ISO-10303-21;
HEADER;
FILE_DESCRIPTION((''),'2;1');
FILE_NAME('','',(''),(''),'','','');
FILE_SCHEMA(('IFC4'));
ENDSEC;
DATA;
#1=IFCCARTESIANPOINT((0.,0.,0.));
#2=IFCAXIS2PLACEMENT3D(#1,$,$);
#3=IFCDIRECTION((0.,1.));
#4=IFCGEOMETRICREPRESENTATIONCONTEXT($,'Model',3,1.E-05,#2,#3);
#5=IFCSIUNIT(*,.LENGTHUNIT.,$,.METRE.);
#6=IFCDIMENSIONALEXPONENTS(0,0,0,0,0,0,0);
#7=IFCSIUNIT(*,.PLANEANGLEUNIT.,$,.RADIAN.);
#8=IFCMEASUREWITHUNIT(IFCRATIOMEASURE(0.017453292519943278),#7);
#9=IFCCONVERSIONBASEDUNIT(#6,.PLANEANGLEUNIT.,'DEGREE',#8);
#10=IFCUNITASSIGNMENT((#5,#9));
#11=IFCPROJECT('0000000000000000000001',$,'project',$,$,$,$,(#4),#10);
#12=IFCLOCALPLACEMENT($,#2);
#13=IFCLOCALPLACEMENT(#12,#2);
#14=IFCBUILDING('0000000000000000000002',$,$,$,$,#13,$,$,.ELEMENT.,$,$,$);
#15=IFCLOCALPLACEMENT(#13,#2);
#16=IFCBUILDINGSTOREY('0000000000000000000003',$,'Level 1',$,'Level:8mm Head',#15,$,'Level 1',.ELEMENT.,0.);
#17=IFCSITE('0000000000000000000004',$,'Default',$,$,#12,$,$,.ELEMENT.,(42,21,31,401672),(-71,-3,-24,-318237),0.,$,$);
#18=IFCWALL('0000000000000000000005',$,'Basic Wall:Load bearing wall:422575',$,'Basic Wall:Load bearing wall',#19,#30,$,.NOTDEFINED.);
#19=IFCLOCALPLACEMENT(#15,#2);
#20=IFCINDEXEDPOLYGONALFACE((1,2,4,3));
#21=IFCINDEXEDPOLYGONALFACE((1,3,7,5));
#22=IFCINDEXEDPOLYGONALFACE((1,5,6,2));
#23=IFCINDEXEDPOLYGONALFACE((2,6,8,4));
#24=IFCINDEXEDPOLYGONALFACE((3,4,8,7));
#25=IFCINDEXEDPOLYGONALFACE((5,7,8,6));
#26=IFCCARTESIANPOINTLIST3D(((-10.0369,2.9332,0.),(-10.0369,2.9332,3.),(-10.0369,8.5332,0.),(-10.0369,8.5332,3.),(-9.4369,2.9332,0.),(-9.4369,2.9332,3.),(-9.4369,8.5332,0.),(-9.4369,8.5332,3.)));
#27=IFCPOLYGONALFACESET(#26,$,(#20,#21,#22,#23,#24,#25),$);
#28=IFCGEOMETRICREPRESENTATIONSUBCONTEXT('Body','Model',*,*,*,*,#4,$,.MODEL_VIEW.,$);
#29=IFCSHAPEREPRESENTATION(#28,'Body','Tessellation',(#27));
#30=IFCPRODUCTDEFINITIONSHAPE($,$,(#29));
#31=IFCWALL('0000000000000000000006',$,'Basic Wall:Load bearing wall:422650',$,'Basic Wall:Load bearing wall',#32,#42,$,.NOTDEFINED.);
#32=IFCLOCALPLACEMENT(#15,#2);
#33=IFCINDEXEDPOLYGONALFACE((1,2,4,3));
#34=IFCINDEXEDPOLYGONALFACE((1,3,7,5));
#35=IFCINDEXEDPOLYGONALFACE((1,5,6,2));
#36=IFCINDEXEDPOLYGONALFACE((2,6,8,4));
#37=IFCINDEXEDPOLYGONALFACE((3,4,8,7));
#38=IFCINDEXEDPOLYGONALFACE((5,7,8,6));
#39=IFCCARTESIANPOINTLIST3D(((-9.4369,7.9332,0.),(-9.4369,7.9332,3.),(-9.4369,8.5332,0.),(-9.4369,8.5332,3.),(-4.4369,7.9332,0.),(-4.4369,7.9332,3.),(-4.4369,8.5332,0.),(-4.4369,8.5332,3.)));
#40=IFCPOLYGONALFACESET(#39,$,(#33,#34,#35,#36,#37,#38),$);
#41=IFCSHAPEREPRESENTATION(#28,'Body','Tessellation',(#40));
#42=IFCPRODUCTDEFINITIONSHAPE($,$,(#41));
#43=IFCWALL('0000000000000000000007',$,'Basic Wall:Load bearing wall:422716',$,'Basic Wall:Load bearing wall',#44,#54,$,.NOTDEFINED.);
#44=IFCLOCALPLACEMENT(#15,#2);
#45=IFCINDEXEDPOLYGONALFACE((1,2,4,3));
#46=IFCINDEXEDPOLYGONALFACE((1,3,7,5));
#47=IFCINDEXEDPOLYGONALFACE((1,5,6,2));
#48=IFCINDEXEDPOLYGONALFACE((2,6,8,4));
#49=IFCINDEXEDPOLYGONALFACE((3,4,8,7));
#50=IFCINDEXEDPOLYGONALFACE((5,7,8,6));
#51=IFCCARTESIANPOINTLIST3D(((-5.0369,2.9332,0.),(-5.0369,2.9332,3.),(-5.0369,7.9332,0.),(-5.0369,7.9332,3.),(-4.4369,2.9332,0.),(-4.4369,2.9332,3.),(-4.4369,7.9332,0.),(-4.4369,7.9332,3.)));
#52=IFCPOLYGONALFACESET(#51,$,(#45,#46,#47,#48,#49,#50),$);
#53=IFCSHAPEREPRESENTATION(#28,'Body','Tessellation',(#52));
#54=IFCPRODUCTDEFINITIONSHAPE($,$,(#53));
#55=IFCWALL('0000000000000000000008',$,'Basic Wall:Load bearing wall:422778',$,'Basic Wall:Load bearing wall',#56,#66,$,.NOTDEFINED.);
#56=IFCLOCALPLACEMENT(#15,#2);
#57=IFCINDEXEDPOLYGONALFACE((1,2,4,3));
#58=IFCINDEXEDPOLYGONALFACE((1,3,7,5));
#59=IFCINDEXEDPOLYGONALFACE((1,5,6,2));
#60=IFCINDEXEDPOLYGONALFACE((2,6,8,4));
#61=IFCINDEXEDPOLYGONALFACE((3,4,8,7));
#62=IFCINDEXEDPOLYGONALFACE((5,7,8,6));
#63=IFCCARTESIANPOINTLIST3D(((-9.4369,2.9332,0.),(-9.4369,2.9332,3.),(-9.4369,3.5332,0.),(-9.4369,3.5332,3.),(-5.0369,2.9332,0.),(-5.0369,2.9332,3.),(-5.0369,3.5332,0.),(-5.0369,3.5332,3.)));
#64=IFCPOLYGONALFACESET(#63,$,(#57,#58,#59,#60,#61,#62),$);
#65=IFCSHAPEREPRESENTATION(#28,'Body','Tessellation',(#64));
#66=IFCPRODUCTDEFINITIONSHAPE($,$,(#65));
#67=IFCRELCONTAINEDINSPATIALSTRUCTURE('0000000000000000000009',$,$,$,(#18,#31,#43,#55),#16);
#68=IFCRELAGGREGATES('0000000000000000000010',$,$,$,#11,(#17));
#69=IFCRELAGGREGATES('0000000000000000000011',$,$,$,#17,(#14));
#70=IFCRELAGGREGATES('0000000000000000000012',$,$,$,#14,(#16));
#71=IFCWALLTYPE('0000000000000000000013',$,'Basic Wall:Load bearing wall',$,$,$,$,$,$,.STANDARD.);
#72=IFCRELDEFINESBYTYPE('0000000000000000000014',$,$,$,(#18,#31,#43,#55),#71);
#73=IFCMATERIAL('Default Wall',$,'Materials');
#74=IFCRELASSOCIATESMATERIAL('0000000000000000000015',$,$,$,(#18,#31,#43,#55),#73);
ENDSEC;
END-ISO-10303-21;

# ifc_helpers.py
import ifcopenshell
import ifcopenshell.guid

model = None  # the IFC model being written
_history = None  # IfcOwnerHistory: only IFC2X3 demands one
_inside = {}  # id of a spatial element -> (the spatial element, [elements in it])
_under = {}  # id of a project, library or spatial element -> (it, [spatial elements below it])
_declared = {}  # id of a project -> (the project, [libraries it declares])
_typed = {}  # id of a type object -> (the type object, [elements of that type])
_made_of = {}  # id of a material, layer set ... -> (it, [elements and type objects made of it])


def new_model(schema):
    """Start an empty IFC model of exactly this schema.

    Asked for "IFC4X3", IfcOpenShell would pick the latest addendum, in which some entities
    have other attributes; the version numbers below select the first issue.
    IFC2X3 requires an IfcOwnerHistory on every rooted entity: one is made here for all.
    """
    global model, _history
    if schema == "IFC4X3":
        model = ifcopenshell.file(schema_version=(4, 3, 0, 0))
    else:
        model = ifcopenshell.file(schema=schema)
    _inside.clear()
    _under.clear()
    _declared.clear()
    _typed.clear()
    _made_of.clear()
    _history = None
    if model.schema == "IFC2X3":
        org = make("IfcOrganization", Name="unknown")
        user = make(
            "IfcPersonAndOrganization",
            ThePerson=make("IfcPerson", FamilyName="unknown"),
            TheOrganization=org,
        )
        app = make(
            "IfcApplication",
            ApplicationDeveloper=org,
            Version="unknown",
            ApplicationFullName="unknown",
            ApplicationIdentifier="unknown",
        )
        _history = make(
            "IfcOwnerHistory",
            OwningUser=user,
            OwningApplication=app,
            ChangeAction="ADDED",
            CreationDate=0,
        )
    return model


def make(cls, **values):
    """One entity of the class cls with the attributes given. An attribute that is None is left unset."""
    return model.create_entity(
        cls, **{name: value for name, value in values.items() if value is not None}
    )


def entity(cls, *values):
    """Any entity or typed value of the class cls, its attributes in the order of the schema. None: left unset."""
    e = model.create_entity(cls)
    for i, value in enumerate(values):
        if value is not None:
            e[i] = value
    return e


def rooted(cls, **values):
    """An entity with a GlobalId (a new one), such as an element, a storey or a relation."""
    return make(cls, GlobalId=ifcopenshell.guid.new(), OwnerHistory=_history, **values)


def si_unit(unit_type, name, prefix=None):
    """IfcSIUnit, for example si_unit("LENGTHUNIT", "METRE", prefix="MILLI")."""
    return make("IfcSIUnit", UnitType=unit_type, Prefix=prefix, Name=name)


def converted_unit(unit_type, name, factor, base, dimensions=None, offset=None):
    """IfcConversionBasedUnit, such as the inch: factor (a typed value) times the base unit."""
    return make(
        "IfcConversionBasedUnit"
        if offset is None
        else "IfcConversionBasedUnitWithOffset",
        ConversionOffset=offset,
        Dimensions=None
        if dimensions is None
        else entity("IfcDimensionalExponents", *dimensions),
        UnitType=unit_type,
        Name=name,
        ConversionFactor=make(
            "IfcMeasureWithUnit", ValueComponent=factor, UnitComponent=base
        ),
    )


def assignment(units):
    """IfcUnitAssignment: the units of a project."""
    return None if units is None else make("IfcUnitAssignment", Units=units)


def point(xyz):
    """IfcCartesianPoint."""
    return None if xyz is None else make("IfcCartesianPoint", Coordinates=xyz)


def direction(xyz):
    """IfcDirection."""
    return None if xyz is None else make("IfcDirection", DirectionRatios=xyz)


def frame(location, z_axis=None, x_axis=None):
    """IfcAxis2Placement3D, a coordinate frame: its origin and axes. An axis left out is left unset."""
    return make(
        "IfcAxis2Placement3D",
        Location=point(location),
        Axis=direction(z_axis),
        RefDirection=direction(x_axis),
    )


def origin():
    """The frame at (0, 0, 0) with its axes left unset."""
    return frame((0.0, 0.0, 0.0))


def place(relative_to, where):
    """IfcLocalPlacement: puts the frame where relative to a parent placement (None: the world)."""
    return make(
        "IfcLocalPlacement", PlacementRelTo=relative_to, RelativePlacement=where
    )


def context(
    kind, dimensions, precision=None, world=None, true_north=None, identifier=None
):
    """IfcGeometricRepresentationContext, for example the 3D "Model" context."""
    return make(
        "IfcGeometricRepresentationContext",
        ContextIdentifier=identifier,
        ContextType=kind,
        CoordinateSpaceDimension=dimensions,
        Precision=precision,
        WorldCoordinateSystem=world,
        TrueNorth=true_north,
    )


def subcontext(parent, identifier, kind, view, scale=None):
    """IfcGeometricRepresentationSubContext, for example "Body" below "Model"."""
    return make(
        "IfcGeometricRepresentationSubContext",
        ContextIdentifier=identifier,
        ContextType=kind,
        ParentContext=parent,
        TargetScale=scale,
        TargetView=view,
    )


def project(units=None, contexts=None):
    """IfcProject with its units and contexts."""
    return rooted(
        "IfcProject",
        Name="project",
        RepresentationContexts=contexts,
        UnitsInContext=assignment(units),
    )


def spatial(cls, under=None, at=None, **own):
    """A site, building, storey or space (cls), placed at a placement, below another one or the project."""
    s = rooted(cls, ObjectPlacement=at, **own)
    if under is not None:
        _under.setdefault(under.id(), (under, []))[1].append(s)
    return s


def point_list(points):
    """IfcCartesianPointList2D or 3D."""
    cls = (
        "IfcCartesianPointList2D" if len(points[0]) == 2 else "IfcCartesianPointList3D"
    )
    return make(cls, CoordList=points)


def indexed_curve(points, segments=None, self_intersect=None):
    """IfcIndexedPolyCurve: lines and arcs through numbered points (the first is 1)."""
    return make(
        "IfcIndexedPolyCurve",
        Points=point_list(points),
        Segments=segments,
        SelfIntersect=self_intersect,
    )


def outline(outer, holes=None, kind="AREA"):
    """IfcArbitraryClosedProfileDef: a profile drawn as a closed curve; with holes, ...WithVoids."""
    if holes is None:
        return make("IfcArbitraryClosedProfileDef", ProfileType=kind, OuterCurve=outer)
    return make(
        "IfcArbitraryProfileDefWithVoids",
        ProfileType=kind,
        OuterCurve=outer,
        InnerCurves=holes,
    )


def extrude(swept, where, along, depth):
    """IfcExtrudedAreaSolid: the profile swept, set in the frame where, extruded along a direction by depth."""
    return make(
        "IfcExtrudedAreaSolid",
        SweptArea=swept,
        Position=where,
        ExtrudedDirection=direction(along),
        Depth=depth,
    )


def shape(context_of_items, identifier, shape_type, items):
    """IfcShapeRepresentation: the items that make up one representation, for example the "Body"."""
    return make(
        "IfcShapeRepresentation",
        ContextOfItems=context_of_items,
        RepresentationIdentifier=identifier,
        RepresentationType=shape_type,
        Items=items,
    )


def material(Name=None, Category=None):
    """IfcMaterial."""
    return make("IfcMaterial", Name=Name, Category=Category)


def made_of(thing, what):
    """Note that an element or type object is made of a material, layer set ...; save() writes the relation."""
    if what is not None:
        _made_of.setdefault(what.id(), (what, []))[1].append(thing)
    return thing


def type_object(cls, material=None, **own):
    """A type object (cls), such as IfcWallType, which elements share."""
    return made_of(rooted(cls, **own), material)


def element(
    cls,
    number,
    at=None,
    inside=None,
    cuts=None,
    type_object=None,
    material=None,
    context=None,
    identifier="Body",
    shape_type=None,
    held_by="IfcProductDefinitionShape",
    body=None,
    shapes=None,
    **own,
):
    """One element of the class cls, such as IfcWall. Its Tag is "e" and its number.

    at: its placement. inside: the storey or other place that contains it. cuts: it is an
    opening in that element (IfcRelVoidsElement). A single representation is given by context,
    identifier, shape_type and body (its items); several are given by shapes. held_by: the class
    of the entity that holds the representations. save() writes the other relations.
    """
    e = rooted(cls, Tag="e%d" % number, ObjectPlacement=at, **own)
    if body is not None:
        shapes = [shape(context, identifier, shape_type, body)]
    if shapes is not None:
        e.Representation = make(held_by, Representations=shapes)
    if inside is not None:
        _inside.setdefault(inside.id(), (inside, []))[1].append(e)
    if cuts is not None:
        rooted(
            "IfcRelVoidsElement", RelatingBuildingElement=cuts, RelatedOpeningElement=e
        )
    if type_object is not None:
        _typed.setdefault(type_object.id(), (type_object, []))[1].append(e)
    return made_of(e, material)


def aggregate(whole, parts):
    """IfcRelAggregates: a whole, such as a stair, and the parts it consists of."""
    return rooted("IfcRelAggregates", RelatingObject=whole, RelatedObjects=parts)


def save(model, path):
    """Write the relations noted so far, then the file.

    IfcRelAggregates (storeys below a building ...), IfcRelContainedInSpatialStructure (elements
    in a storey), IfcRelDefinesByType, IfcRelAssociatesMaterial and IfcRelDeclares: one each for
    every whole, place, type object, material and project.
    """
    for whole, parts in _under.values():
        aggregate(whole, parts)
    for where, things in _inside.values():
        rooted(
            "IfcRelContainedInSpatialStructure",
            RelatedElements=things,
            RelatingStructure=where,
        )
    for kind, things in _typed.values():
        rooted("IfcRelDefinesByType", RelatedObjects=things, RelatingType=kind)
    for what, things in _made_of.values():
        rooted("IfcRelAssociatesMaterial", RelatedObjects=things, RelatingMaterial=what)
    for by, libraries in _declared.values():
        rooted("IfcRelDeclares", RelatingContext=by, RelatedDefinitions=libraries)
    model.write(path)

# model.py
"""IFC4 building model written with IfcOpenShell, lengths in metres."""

from ifc_helpers import new_model, entity, si_unit, converted_unit, direction, frame, origin, place, context, subcontext, project, spatial, indexed_curve, outline, extrude, material, type_object, element, save


model = new_model("IFC4")

# Units and contexts
model_context = context("Model", 3, precision=1e-05, world=origin(), true_north=direction((0.0, 1.0)))
body_context = subcontext(model_context, "Body", "Model", "MODEL_VIEW")
ifc_project = project(units=[si_unit("LENGTHUNIT", "METRE"), converted_unit("PLANEANGLEUNIT", "DEGREE", entity("IfcRatioMeasure", 0.017453292519943278), si_unit("PLANEANGLEUNIT", "RADIAN"), dimensions=[0, 0, 0, 0, 0, 0, 0])], contexts=[model_context])

# Site, building, storey
site_placement = place(None, origin())
site = spatial("IfcSite", under=ifc_project, at=site_placement, Name="Default", CompositionType="ELEMENT", RefLatitude=(42, 21, 31, 401672), RefLongitude=(-71, -3, -24, -318237), RefElevation=0.0)
building_placement = place(site_placement, origin())
building = spatial("IfcBuilding", under=site, at=building_placement, CompositionType="ELEMENT")
storey_placement = place(building_placement, origin())
storey = spatial("IfcBuildingStorey", under=building, at=storey_placement, Name="Level 1", ObjectType="Level:8mm Head", LongName="Level 1", CompositionType="ELEMENT", Elevation=0.0)

# Walls
ifc_material = material(Name="Default Wall", Category="Materials")
wall_type = type_object("IfcWallType", Name="Basic Wall:Load bearing wall", PredefinedType="STANDARD")
wall_1_placement = place(storey_placement, frame((-9.7369, 2.9332, 0.0), z_axis=(0.0, 0.0, 1.0), x_axis=(0.0, 1.0, 0.0)))
element("IfcWall", 1, at=wall_1_placement, inside=storey, type_object=wall_type, material=ifc_material, Name="Basic Wall:Load bearing wall:422575", ObjectType="Basic Wall:Load bearing wall", PredefinedType="NOTDEFINED", context=body_context, shape_type="SweptSolid", body=[
    extrude(outline(indexed_curve([(5.6, 0.3), (0.0, 0.3), (0.0, -0.3), (5.6, -0.3), (5.6, 0.3)], self_intersect=False)), origin(), (0.0, 0.0, 1.0), 3.0),
])
wall_2_placement = place(storey_placement, frame((-9.4369, 8.2332, 0.0)))
element("IfcWall", 2, at=wall_2_placement, inside=storey, type_object=wall_type, material=ifc_material, Name="Basic Wall:Load bearing wall:422650", ObjectType="Basic Wall:Load bearing wall", PredefinedType="NOTDEFINED", context=body_context, shape_type="SweptSolid", body=[
    extrude(outline(indexed_curve([(5.0, 0.3), (0.0, 0.3), (0.0, -0.3), (5.0, -0.3), (5.0, 0.3)], self_intersect=False)), origin(), (0.0, 0.0, 1.0), 3.0),
])
wall_3_placement = place(storey_placement, frame((-4.7369, 7.9332, 0.0), z_axis=(0.0, 0.0, 1.0), x_axis=(0.0, -1.0, 0.0)))
element("IfcWall", 3, at=wall_3_placement, inside=storey, type_object=wall_type, material=ifc_material, Name="Basic Wall:Load bearing wall:422716", ObjectType="Basic Wall:Load bearing wall", PredefinedType="NOTDEFINED", context=body_context, shape_type="SweptSolid", body=[
    extrude(outline(indexed_curve([(5.0, 0.3), (0.0, 0.3), (0.0, -0.3), (5.0, -0.3), (5.0, 0.3)], self_intersect=False)), origin(), (0.0, 0.0, 1.0), 3.0),
])
wall_4_placement = place(storey_placement, frame((-5.0369, 3.2332, 0.0), z_axis=(0.0, 0.0, 1.0), x_axis=(-1.0, 0.0, 0.0)))
element("IfcWall", 4, at=wall_4_placement, inside=storey, type_object=wall_type, material=ifc_material, Name="Basic Wall:Load bearing wall:422778", ObjectType="Basic Wall:Load bearing wall", PredefinedType="NOTDEFINED", context=body_context, shape_type="SweptSolid", body=[
    extrude(outline(indexed_curve([(4.4, 0.3), (0.0, 0.3), (0.0, -0.3), (4.4, -0.3), (4.4, 0.3)], self_intersect=False)), origin(), (0.0, 0.0, 1.0), 3.0),
])

save(model, "model.ifc")
